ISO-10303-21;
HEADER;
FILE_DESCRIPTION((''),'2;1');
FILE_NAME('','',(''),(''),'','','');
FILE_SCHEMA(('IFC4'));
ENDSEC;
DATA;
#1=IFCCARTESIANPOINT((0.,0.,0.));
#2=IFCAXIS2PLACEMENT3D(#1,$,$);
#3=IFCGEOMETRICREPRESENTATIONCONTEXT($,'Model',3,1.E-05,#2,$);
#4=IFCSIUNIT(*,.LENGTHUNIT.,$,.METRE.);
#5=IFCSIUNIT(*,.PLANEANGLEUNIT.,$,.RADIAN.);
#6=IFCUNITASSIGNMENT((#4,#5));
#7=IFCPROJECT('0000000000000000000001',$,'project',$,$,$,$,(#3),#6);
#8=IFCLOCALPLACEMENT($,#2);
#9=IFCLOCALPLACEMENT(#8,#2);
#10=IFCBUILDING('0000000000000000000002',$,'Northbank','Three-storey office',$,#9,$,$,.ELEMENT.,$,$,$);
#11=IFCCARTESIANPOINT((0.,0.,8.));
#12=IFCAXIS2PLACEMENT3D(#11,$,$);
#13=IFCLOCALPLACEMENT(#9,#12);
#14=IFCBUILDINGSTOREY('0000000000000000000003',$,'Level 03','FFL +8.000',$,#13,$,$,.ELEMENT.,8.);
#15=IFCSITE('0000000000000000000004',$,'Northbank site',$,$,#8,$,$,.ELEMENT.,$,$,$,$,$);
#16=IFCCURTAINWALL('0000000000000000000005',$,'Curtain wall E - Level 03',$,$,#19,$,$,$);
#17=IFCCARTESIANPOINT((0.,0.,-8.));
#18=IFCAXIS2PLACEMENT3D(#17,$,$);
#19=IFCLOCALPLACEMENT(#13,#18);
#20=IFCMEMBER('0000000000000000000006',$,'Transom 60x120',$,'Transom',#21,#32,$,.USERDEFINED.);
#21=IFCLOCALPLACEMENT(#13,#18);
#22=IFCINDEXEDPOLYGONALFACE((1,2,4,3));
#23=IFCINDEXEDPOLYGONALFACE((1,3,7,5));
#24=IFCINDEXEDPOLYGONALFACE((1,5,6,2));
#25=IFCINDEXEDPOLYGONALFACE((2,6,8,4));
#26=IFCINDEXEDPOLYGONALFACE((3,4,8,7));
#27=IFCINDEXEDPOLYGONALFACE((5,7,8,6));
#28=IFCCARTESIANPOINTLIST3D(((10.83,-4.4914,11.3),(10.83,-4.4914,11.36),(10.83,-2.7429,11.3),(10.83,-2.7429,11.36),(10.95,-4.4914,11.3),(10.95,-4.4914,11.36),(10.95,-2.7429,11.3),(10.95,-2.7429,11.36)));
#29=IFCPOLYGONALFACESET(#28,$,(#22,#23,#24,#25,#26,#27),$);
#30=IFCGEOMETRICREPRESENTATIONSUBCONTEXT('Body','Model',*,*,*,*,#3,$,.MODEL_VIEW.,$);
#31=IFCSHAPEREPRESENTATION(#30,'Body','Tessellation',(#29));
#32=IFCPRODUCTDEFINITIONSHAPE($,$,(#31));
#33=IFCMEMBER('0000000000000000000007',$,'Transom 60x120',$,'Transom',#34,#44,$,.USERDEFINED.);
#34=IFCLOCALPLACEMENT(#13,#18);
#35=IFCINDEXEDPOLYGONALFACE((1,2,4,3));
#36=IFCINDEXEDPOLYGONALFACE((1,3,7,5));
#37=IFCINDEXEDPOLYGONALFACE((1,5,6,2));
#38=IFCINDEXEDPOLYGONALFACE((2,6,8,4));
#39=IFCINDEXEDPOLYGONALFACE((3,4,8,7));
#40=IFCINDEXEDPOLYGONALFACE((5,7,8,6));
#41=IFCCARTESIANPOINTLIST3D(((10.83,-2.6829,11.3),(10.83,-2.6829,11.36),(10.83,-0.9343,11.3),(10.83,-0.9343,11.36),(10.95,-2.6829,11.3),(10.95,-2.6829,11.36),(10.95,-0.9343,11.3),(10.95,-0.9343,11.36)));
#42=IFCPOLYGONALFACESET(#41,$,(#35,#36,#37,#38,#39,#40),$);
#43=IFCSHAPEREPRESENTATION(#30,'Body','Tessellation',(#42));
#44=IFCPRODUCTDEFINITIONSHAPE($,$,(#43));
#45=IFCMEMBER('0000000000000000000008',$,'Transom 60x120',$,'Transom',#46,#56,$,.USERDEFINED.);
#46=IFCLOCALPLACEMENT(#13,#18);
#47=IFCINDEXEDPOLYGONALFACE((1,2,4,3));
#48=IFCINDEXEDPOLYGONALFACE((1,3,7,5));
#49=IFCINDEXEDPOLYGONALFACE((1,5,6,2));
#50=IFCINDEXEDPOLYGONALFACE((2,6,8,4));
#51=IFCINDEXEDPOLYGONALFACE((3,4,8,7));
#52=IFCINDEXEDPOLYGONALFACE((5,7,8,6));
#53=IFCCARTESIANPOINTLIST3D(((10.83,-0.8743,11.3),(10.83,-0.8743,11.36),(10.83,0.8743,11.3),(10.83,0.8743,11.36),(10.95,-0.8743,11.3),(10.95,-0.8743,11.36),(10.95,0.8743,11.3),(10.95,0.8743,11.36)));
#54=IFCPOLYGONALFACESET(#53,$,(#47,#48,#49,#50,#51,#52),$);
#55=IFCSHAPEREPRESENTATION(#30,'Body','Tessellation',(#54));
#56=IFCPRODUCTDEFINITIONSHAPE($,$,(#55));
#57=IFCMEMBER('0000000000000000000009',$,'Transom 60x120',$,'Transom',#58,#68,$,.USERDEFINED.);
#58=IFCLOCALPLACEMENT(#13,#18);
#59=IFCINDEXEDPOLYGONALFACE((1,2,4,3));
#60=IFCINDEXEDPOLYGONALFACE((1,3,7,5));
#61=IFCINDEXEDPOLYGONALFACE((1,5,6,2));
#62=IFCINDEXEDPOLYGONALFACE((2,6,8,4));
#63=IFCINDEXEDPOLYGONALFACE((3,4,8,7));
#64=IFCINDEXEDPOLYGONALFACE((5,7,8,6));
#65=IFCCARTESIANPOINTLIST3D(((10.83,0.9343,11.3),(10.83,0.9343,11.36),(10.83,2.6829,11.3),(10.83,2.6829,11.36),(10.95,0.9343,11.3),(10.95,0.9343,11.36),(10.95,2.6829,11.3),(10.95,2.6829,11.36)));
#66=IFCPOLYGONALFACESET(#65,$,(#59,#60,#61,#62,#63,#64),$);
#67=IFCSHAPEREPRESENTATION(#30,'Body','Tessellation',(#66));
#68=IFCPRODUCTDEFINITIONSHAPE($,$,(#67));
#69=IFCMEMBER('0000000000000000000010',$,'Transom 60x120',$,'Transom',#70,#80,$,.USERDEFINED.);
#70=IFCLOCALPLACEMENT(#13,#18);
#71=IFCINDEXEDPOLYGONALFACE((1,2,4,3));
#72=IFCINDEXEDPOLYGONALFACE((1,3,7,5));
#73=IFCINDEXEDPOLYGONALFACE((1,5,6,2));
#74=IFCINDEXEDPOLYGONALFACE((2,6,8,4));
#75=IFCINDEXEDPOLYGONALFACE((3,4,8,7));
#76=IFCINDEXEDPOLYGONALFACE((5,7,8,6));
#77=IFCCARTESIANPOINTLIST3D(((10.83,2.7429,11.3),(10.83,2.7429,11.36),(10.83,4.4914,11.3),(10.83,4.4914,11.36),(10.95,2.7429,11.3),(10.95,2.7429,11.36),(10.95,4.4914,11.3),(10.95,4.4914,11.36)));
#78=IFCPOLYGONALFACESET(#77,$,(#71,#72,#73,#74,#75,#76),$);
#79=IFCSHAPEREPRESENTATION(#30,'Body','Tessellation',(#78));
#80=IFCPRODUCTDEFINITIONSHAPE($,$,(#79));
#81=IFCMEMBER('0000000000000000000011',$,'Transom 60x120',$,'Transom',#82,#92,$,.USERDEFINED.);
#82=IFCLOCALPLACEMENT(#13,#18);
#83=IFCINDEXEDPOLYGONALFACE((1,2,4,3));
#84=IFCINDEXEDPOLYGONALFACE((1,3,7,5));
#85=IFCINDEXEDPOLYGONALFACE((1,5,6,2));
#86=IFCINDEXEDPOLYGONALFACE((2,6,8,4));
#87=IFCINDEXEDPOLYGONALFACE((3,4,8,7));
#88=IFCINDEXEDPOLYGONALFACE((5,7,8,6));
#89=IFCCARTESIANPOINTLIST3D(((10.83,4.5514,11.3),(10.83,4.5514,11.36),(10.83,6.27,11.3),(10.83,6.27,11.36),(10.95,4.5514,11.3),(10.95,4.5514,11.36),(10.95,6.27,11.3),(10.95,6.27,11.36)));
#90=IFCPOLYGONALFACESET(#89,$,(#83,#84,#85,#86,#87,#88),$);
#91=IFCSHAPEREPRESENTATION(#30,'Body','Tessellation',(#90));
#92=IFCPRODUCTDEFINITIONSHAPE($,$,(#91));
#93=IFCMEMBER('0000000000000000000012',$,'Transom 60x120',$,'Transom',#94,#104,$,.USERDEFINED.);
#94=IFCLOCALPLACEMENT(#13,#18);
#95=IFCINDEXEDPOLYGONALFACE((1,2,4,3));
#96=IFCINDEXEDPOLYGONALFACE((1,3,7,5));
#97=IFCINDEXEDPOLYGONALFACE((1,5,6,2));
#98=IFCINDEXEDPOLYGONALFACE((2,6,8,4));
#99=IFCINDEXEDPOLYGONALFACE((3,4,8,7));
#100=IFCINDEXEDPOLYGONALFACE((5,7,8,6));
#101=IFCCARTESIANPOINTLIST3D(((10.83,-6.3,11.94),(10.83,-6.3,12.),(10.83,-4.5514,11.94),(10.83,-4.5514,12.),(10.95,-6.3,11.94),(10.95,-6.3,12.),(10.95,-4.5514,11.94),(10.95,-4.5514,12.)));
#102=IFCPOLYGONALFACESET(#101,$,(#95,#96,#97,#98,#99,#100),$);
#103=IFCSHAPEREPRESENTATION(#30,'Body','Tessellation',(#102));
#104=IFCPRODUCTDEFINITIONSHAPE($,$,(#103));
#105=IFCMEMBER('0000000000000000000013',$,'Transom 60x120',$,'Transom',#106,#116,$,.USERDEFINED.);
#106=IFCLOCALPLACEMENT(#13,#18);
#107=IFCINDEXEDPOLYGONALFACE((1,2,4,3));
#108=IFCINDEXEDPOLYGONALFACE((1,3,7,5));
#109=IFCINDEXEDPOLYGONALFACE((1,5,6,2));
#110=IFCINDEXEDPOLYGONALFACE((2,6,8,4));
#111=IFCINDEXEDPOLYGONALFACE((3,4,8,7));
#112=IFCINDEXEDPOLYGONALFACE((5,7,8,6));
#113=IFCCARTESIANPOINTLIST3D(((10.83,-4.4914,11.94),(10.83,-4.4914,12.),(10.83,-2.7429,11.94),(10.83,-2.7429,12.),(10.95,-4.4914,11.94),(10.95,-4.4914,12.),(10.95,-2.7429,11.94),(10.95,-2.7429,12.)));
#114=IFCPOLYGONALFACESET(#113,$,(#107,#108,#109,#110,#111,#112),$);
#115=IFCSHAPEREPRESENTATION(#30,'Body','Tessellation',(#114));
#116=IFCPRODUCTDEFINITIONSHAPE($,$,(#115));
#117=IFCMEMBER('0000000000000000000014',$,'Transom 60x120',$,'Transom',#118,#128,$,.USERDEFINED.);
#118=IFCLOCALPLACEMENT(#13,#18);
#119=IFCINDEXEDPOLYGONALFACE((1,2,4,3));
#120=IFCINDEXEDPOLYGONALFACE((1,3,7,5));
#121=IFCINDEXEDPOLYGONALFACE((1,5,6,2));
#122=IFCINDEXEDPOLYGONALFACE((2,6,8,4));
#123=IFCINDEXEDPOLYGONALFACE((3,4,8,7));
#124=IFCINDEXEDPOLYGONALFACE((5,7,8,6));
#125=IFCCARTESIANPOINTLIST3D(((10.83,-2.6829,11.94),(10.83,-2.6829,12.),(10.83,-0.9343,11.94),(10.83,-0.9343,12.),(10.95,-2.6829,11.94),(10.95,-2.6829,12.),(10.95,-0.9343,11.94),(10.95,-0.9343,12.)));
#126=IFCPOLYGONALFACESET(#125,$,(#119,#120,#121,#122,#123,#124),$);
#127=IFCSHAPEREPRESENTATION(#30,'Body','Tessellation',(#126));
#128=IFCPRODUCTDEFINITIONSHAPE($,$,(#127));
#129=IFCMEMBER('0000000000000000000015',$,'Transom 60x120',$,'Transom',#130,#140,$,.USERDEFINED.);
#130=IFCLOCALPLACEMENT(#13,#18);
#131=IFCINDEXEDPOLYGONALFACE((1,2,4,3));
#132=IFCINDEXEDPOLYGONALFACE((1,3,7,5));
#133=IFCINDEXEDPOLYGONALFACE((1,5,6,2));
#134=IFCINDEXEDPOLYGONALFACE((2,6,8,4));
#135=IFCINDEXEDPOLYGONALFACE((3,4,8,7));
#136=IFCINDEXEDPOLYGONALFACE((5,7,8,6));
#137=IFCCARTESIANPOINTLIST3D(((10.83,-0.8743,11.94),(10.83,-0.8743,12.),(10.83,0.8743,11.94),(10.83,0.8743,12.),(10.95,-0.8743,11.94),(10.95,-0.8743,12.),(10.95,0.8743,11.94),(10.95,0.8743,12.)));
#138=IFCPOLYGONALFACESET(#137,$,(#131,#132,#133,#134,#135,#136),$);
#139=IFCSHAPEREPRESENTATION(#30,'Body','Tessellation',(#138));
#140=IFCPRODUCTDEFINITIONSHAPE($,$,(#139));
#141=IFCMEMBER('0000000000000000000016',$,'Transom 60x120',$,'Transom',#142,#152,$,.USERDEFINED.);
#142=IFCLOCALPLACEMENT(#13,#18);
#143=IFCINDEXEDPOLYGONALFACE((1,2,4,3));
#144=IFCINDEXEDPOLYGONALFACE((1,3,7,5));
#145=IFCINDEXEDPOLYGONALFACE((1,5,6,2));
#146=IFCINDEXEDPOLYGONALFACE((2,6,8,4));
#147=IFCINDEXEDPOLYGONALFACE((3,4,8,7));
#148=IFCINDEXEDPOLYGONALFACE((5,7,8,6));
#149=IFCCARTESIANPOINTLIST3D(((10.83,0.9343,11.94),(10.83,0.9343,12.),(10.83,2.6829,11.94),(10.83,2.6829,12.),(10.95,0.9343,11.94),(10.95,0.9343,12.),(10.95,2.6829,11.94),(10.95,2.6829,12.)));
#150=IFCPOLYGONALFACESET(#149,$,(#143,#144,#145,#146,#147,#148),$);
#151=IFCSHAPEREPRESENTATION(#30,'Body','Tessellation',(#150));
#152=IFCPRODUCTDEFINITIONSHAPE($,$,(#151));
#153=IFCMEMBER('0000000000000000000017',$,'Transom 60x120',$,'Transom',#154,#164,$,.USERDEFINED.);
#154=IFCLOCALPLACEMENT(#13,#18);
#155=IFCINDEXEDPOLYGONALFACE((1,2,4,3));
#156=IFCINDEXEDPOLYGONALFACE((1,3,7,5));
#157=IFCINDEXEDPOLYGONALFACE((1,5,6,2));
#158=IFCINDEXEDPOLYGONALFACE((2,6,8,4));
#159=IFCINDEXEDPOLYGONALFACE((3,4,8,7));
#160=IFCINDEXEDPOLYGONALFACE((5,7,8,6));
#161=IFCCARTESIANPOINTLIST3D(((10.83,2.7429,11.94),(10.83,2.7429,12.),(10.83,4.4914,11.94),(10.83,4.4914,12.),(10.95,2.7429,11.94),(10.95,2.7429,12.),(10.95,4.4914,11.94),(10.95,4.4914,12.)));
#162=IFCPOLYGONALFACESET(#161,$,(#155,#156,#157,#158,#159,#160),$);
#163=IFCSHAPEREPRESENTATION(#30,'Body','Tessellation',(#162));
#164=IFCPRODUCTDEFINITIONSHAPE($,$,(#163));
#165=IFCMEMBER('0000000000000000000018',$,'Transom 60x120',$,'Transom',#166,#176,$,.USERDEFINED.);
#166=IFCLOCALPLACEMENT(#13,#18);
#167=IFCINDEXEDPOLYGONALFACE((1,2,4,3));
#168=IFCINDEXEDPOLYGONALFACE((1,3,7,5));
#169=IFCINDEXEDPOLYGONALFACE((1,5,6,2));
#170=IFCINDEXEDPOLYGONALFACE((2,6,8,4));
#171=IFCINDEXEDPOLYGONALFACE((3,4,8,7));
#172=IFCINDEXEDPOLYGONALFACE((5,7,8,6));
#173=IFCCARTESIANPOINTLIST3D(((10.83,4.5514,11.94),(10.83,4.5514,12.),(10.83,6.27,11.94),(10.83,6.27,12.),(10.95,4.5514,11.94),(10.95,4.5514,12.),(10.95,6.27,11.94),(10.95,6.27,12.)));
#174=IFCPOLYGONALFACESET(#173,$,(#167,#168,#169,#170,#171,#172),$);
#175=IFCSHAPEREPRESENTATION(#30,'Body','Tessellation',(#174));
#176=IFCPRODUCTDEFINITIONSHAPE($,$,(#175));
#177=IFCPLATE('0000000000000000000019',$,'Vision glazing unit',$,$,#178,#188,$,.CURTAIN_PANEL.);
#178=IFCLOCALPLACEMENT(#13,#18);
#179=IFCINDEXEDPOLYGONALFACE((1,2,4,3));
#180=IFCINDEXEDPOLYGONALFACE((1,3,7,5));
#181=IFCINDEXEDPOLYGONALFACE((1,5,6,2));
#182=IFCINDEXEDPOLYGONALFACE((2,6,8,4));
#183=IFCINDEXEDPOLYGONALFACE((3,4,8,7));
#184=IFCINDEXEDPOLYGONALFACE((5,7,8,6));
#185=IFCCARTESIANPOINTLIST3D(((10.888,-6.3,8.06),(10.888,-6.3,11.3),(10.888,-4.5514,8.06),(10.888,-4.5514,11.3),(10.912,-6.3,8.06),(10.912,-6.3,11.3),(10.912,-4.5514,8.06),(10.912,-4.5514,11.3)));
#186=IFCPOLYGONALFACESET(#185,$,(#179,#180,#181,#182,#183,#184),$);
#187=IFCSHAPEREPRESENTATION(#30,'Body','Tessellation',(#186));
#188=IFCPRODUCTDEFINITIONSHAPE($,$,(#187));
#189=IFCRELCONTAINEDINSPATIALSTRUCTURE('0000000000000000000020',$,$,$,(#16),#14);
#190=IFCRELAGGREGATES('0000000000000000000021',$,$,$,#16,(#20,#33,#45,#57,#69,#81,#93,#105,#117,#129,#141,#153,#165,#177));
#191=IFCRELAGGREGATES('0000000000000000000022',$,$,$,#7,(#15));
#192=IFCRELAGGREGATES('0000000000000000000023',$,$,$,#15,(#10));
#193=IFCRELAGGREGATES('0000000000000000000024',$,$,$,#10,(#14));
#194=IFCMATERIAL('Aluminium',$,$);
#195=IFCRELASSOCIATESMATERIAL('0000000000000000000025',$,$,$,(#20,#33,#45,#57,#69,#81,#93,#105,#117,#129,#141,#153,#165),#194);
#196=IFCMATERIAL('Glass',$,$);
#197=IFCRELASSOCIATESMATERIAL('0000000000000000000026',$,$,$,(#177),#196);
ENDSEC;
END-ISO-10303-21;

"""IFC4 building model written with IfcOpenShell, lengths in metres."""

from ifc_helpers import new_model, si_unit, frame, origin, place, context, subcontext, project, spatial, rectangle, extrude, material, element, aggregate, save


model = new_model("IFC4")

# Units and contexts
model_context = context("Model", 3, precision=1e-05, world=origin())
body_context = subcontext(model_context, "Body", "Model", "MODEL_VIEW")
ifc_project = project(units=[si_unit("LENGTHUNIT", "METRE"), si_unit("PLANEANGLEUNIT", "RADIAN")], contexts=[model_context])

# Site, building, storey
site_placement = place(None, origin())
site = spatial("IfcSite", under=ifc_project, at=site_placement, Name="Northbank site", CompositionType="ELEMENT")
building_placement = place(site_placement, origin())
building = spatial("IfcBuilding", under=site, at=building_placement, Name="Northbank", Description="Three-storey office", CompositionType="ELEMENT")
storey_placement = place(building_placement, frame((0.0, 0.0, 8.0)))
storey = spatial("IfcBuildingStorey", under=building, at=storey_placement, Name="Level 03", Description="FFL +8.000", CompositionType="ELEMENT", Elevation=8.0)

# Curtain wall, members, plate
curtain_wall_placement = place(storey_placement, frame((0.0, 0.0, -8.0)))
curtain_wall = element("IfcCurtainWall", 1, at=curtain_wall_placement, inside=storey, Name="Curtain wall E - Level 03")
ifc_material_1 = material(Name="Aluminium")
member_1_placement = place(storey_placement, frame((0.0, 0.0, -8.0)))
member_1 = element("IfcMember", 2, at=member_1_placement, material=ifc_material_1, Name="Transom 60x120", ObjectType="Transom", PredefinedType="USERDEFINED", context=body_context, shape_type="SweptSolid", body=[
    extrude(rectangle(XDim=0.12, YDim=1.7486), frame((10.89, -3.6171, 11.3)), (0.0, 0.0, 1.0), 0.06),
])
member_2_placement = place(storey_placement, frame((0.0, 0.0, -8.0)))
member_2 = element("IfcMember", 3, at=member_2_placement, material=ifc_material_1, Name="Transom 60x120", ObjectType="Transom", PredefinedType="USERDEFINED", context=body_context, shape_type="SweptSolid", body=[
    extrude(rectangle(XDim=0.12, YDim=1.7486), frame((10.89, -1.8086, 11.3)), (0.0, 0.0, 1.0), 0.06),
])
member_3_placement = place(storey_placement, frame((0.0, 0.0, -8.0)))
member_3 = element("IfcMember", 4, at=member_3_placement, material=ifc_material_1, Name="Transom 60x120", ObjectType="Transom", PredefinedType="USERDEFINED", context=body_context, shape_type="SweptSolid", body=[
    extrude(rectangle(XDim=0.12, YDim=1.7486), frame((10.89, 0.0, 11.3)), (0.0, 0.0, 1.0), 0.06),
])
member_4_placement = place(storey_placement, frame((0.0, 0.0, -8.0)))
member_4 = element("IfcMember", 5, at=member_4_placement, material=ifc_material_1, Name="Transom 60x120", ObjectType="Transom", PredefinedType="USERDEFINED", context=body_context, shape_type="SweptSolid", body=[
    extrude(rectangle(XDim=0.12, YDim=1.7486), frame((10.89, 1.8086, 11.3)), (0.0, 0.0, 1.0), 0.06),
])
member_5_placement = place(storey_placement, frame((0.0, 0.0, -8.0)))
member_5 = element("IfcMember", 6, at=member_5_placement, material=ifc_material_1, Name="Transom 60x120", ObjectType="Transom", PredefinedType="USERDEFINED", context=body_context, shape_type="SweptSolid", body=[
    extrude(rectangle(XDim=0.12, YDim=1.7486), frame((10.89, 3.6171, 11.3)), (0.0, 0.0, 1.0), 0.06),
])
member_6_placement = place(storey_placement, frame((0.0, 0.0, -8.0)))
member_6 = element("IfcMember", 7, at=member_6_placement, material=ifc_material_1, Name="Transom 60x120", ObjectType="Transom", PredefinedType="USERDEFINED", context=body_context, shape_type="SweptSolid", body=[
    extrude(rectangle(XDim=0.12, YDim=1.7186), frame((10.89, 5.4107, 11.3)), (0.0, 0.0, 1.0), 0.06),
])
member_7_placement = place(storey_placement, frame((0.0, 0.0, -8.0)))
member_7 = element("IfcMember", 8, at=member_7_placement, material=ifc_material_1, Name="Transom 60x120", ObjectType="Transom", PredefinedType="USERDEFINED", context=body_context, shape_type="SweptSolid", body=[
    extrude(rectangle(XDim=0.12, YDim=1.7486), frame((10.89, -5.4257, 11.94)), (0.0, 0.0, 1.0), 0.06),
])
member_8_placement = place(storey_placement, frame((0.0, 0.0, -8.0)))
member_8 = element("IfcMember", 9, at=member_8_placement, material=ifc_material_1, Name="Transom 60x120", ObjectType="Transom", PredefinedType="USERDEFINED", context=body_context, shape_type="SweptSolid", body=[
    extrude(rectangle(XDim=0.12, YDim=1.7486), frame((10.89, -3.6171, 11.94)), (0.0, 0.0, 1.0), 0.06),
])
member_9_placement = place(storey_placement, frame((0.0, 0.0, -8.0)))
member_9 = element("IfcMember", 10, at=member_9_placement, material=ifc_material_1, Name="Transom 60x120", ObjectType="Transom", PredefinedType="USERDEFINED", context=body_context, shape_type="SweptSolid", body=[
    extrude(rectangle(XDim=0.12, YDim=1.7486), frame((10.89, -1.8086, 11.94)), (0.0, 0.0, 1.0), 0.06),
])
member_10_placement = place(storey_placement, frame((0.0, 0.0, -8.0)))
member_10 = element("IfcMember", 11, at=member_10_placement, material=ifc_material_1, Name="Transom 60x120", ObjectType="Transom", PredefinedType="USERDEFINED", context=body_context, shape_type="SweptSolid", body=[
    extrude(rectangle(XDim=0.12, YDim=1.7486), frame((10.89, 0.0, 11.94)), (0.0, 0.0, 1.0), 0.06),
])
member_11_placement = place(storey_placement, frame((0.0, 0.0, -8.0)))
member_11 = element("IfcMember", 12, at=member_11_placement, material=ifc_material_1, Name="Transom 60x120", ObjectType="Transom", PredefinedType="USERDEFINED", context=body_context, shape_type="SweptSolid", body=[
    extrude(rectangle(XDim=0.12, YDim=1.7486), frame((10.89, 1.8086, 11.94)), (0.0, 0.0, 1.0), 0.06),
])
member_12_placement = place(storey_placement, frame((0.0, 0.0, -8.0)))
member_12 = element("IfcMember", 13, at=member_12_placement, material=ifc_material_1, Name="Transom 60x120", ObjectType="Transom", PredefinedType="USERDEFINED", context=body_context, shape_type="SweptSolid", body=[
    extrude(rectangle(XDim=0.12, YDim=1.7486), frame((10.89, 3.6171, 11.94)), (0.0, 0.0, 1.0), 0.06),
])
member_13_placement = place(storey_placement, frame((0.0, 0.0, -8.0)))
member_13 = element("IfcMember", 14, at=member_13_placement, material=ifc_material_1, Name="Transom 60x120", ObjectType="Transom", PredefinedType="USERDEFINED", context=body_context, shape_type="SweptSolid", body=[
    extrude(rectangle(XDim=0.12, YDim=1.7186), frame((10.89, 5.4107, 11.94)), (0.0, 0.0, 1.0), 0.06),
])
ifc_material_2 = material(Name="Glass")
plate_1_placement = place(storey_placement, frame((0.0, 0.0, -8.0)))
plate_1 = element("IfcPlate", 15, at=plate_1_placement, material=ifc_material_2, Name="Vision glazing unit", PredefinedType="CURTAIN_PANEL", context=body_context, shape_type="SweptSolid", body=[
    extrude(rectangle(XDim=0.024, YDim=1.7486), frame((10.9, -5.4257, 8.06)), (0.0, 0.0, 1.0), 3.24),
])
aggregate(curtain_wall, [member_1, member_2, member_3, member_4, member_5, member_6, member_7, member_8, member_9, member_10, member_11, member_12, member_13, plate_1])

save(model, "model.ifc")
